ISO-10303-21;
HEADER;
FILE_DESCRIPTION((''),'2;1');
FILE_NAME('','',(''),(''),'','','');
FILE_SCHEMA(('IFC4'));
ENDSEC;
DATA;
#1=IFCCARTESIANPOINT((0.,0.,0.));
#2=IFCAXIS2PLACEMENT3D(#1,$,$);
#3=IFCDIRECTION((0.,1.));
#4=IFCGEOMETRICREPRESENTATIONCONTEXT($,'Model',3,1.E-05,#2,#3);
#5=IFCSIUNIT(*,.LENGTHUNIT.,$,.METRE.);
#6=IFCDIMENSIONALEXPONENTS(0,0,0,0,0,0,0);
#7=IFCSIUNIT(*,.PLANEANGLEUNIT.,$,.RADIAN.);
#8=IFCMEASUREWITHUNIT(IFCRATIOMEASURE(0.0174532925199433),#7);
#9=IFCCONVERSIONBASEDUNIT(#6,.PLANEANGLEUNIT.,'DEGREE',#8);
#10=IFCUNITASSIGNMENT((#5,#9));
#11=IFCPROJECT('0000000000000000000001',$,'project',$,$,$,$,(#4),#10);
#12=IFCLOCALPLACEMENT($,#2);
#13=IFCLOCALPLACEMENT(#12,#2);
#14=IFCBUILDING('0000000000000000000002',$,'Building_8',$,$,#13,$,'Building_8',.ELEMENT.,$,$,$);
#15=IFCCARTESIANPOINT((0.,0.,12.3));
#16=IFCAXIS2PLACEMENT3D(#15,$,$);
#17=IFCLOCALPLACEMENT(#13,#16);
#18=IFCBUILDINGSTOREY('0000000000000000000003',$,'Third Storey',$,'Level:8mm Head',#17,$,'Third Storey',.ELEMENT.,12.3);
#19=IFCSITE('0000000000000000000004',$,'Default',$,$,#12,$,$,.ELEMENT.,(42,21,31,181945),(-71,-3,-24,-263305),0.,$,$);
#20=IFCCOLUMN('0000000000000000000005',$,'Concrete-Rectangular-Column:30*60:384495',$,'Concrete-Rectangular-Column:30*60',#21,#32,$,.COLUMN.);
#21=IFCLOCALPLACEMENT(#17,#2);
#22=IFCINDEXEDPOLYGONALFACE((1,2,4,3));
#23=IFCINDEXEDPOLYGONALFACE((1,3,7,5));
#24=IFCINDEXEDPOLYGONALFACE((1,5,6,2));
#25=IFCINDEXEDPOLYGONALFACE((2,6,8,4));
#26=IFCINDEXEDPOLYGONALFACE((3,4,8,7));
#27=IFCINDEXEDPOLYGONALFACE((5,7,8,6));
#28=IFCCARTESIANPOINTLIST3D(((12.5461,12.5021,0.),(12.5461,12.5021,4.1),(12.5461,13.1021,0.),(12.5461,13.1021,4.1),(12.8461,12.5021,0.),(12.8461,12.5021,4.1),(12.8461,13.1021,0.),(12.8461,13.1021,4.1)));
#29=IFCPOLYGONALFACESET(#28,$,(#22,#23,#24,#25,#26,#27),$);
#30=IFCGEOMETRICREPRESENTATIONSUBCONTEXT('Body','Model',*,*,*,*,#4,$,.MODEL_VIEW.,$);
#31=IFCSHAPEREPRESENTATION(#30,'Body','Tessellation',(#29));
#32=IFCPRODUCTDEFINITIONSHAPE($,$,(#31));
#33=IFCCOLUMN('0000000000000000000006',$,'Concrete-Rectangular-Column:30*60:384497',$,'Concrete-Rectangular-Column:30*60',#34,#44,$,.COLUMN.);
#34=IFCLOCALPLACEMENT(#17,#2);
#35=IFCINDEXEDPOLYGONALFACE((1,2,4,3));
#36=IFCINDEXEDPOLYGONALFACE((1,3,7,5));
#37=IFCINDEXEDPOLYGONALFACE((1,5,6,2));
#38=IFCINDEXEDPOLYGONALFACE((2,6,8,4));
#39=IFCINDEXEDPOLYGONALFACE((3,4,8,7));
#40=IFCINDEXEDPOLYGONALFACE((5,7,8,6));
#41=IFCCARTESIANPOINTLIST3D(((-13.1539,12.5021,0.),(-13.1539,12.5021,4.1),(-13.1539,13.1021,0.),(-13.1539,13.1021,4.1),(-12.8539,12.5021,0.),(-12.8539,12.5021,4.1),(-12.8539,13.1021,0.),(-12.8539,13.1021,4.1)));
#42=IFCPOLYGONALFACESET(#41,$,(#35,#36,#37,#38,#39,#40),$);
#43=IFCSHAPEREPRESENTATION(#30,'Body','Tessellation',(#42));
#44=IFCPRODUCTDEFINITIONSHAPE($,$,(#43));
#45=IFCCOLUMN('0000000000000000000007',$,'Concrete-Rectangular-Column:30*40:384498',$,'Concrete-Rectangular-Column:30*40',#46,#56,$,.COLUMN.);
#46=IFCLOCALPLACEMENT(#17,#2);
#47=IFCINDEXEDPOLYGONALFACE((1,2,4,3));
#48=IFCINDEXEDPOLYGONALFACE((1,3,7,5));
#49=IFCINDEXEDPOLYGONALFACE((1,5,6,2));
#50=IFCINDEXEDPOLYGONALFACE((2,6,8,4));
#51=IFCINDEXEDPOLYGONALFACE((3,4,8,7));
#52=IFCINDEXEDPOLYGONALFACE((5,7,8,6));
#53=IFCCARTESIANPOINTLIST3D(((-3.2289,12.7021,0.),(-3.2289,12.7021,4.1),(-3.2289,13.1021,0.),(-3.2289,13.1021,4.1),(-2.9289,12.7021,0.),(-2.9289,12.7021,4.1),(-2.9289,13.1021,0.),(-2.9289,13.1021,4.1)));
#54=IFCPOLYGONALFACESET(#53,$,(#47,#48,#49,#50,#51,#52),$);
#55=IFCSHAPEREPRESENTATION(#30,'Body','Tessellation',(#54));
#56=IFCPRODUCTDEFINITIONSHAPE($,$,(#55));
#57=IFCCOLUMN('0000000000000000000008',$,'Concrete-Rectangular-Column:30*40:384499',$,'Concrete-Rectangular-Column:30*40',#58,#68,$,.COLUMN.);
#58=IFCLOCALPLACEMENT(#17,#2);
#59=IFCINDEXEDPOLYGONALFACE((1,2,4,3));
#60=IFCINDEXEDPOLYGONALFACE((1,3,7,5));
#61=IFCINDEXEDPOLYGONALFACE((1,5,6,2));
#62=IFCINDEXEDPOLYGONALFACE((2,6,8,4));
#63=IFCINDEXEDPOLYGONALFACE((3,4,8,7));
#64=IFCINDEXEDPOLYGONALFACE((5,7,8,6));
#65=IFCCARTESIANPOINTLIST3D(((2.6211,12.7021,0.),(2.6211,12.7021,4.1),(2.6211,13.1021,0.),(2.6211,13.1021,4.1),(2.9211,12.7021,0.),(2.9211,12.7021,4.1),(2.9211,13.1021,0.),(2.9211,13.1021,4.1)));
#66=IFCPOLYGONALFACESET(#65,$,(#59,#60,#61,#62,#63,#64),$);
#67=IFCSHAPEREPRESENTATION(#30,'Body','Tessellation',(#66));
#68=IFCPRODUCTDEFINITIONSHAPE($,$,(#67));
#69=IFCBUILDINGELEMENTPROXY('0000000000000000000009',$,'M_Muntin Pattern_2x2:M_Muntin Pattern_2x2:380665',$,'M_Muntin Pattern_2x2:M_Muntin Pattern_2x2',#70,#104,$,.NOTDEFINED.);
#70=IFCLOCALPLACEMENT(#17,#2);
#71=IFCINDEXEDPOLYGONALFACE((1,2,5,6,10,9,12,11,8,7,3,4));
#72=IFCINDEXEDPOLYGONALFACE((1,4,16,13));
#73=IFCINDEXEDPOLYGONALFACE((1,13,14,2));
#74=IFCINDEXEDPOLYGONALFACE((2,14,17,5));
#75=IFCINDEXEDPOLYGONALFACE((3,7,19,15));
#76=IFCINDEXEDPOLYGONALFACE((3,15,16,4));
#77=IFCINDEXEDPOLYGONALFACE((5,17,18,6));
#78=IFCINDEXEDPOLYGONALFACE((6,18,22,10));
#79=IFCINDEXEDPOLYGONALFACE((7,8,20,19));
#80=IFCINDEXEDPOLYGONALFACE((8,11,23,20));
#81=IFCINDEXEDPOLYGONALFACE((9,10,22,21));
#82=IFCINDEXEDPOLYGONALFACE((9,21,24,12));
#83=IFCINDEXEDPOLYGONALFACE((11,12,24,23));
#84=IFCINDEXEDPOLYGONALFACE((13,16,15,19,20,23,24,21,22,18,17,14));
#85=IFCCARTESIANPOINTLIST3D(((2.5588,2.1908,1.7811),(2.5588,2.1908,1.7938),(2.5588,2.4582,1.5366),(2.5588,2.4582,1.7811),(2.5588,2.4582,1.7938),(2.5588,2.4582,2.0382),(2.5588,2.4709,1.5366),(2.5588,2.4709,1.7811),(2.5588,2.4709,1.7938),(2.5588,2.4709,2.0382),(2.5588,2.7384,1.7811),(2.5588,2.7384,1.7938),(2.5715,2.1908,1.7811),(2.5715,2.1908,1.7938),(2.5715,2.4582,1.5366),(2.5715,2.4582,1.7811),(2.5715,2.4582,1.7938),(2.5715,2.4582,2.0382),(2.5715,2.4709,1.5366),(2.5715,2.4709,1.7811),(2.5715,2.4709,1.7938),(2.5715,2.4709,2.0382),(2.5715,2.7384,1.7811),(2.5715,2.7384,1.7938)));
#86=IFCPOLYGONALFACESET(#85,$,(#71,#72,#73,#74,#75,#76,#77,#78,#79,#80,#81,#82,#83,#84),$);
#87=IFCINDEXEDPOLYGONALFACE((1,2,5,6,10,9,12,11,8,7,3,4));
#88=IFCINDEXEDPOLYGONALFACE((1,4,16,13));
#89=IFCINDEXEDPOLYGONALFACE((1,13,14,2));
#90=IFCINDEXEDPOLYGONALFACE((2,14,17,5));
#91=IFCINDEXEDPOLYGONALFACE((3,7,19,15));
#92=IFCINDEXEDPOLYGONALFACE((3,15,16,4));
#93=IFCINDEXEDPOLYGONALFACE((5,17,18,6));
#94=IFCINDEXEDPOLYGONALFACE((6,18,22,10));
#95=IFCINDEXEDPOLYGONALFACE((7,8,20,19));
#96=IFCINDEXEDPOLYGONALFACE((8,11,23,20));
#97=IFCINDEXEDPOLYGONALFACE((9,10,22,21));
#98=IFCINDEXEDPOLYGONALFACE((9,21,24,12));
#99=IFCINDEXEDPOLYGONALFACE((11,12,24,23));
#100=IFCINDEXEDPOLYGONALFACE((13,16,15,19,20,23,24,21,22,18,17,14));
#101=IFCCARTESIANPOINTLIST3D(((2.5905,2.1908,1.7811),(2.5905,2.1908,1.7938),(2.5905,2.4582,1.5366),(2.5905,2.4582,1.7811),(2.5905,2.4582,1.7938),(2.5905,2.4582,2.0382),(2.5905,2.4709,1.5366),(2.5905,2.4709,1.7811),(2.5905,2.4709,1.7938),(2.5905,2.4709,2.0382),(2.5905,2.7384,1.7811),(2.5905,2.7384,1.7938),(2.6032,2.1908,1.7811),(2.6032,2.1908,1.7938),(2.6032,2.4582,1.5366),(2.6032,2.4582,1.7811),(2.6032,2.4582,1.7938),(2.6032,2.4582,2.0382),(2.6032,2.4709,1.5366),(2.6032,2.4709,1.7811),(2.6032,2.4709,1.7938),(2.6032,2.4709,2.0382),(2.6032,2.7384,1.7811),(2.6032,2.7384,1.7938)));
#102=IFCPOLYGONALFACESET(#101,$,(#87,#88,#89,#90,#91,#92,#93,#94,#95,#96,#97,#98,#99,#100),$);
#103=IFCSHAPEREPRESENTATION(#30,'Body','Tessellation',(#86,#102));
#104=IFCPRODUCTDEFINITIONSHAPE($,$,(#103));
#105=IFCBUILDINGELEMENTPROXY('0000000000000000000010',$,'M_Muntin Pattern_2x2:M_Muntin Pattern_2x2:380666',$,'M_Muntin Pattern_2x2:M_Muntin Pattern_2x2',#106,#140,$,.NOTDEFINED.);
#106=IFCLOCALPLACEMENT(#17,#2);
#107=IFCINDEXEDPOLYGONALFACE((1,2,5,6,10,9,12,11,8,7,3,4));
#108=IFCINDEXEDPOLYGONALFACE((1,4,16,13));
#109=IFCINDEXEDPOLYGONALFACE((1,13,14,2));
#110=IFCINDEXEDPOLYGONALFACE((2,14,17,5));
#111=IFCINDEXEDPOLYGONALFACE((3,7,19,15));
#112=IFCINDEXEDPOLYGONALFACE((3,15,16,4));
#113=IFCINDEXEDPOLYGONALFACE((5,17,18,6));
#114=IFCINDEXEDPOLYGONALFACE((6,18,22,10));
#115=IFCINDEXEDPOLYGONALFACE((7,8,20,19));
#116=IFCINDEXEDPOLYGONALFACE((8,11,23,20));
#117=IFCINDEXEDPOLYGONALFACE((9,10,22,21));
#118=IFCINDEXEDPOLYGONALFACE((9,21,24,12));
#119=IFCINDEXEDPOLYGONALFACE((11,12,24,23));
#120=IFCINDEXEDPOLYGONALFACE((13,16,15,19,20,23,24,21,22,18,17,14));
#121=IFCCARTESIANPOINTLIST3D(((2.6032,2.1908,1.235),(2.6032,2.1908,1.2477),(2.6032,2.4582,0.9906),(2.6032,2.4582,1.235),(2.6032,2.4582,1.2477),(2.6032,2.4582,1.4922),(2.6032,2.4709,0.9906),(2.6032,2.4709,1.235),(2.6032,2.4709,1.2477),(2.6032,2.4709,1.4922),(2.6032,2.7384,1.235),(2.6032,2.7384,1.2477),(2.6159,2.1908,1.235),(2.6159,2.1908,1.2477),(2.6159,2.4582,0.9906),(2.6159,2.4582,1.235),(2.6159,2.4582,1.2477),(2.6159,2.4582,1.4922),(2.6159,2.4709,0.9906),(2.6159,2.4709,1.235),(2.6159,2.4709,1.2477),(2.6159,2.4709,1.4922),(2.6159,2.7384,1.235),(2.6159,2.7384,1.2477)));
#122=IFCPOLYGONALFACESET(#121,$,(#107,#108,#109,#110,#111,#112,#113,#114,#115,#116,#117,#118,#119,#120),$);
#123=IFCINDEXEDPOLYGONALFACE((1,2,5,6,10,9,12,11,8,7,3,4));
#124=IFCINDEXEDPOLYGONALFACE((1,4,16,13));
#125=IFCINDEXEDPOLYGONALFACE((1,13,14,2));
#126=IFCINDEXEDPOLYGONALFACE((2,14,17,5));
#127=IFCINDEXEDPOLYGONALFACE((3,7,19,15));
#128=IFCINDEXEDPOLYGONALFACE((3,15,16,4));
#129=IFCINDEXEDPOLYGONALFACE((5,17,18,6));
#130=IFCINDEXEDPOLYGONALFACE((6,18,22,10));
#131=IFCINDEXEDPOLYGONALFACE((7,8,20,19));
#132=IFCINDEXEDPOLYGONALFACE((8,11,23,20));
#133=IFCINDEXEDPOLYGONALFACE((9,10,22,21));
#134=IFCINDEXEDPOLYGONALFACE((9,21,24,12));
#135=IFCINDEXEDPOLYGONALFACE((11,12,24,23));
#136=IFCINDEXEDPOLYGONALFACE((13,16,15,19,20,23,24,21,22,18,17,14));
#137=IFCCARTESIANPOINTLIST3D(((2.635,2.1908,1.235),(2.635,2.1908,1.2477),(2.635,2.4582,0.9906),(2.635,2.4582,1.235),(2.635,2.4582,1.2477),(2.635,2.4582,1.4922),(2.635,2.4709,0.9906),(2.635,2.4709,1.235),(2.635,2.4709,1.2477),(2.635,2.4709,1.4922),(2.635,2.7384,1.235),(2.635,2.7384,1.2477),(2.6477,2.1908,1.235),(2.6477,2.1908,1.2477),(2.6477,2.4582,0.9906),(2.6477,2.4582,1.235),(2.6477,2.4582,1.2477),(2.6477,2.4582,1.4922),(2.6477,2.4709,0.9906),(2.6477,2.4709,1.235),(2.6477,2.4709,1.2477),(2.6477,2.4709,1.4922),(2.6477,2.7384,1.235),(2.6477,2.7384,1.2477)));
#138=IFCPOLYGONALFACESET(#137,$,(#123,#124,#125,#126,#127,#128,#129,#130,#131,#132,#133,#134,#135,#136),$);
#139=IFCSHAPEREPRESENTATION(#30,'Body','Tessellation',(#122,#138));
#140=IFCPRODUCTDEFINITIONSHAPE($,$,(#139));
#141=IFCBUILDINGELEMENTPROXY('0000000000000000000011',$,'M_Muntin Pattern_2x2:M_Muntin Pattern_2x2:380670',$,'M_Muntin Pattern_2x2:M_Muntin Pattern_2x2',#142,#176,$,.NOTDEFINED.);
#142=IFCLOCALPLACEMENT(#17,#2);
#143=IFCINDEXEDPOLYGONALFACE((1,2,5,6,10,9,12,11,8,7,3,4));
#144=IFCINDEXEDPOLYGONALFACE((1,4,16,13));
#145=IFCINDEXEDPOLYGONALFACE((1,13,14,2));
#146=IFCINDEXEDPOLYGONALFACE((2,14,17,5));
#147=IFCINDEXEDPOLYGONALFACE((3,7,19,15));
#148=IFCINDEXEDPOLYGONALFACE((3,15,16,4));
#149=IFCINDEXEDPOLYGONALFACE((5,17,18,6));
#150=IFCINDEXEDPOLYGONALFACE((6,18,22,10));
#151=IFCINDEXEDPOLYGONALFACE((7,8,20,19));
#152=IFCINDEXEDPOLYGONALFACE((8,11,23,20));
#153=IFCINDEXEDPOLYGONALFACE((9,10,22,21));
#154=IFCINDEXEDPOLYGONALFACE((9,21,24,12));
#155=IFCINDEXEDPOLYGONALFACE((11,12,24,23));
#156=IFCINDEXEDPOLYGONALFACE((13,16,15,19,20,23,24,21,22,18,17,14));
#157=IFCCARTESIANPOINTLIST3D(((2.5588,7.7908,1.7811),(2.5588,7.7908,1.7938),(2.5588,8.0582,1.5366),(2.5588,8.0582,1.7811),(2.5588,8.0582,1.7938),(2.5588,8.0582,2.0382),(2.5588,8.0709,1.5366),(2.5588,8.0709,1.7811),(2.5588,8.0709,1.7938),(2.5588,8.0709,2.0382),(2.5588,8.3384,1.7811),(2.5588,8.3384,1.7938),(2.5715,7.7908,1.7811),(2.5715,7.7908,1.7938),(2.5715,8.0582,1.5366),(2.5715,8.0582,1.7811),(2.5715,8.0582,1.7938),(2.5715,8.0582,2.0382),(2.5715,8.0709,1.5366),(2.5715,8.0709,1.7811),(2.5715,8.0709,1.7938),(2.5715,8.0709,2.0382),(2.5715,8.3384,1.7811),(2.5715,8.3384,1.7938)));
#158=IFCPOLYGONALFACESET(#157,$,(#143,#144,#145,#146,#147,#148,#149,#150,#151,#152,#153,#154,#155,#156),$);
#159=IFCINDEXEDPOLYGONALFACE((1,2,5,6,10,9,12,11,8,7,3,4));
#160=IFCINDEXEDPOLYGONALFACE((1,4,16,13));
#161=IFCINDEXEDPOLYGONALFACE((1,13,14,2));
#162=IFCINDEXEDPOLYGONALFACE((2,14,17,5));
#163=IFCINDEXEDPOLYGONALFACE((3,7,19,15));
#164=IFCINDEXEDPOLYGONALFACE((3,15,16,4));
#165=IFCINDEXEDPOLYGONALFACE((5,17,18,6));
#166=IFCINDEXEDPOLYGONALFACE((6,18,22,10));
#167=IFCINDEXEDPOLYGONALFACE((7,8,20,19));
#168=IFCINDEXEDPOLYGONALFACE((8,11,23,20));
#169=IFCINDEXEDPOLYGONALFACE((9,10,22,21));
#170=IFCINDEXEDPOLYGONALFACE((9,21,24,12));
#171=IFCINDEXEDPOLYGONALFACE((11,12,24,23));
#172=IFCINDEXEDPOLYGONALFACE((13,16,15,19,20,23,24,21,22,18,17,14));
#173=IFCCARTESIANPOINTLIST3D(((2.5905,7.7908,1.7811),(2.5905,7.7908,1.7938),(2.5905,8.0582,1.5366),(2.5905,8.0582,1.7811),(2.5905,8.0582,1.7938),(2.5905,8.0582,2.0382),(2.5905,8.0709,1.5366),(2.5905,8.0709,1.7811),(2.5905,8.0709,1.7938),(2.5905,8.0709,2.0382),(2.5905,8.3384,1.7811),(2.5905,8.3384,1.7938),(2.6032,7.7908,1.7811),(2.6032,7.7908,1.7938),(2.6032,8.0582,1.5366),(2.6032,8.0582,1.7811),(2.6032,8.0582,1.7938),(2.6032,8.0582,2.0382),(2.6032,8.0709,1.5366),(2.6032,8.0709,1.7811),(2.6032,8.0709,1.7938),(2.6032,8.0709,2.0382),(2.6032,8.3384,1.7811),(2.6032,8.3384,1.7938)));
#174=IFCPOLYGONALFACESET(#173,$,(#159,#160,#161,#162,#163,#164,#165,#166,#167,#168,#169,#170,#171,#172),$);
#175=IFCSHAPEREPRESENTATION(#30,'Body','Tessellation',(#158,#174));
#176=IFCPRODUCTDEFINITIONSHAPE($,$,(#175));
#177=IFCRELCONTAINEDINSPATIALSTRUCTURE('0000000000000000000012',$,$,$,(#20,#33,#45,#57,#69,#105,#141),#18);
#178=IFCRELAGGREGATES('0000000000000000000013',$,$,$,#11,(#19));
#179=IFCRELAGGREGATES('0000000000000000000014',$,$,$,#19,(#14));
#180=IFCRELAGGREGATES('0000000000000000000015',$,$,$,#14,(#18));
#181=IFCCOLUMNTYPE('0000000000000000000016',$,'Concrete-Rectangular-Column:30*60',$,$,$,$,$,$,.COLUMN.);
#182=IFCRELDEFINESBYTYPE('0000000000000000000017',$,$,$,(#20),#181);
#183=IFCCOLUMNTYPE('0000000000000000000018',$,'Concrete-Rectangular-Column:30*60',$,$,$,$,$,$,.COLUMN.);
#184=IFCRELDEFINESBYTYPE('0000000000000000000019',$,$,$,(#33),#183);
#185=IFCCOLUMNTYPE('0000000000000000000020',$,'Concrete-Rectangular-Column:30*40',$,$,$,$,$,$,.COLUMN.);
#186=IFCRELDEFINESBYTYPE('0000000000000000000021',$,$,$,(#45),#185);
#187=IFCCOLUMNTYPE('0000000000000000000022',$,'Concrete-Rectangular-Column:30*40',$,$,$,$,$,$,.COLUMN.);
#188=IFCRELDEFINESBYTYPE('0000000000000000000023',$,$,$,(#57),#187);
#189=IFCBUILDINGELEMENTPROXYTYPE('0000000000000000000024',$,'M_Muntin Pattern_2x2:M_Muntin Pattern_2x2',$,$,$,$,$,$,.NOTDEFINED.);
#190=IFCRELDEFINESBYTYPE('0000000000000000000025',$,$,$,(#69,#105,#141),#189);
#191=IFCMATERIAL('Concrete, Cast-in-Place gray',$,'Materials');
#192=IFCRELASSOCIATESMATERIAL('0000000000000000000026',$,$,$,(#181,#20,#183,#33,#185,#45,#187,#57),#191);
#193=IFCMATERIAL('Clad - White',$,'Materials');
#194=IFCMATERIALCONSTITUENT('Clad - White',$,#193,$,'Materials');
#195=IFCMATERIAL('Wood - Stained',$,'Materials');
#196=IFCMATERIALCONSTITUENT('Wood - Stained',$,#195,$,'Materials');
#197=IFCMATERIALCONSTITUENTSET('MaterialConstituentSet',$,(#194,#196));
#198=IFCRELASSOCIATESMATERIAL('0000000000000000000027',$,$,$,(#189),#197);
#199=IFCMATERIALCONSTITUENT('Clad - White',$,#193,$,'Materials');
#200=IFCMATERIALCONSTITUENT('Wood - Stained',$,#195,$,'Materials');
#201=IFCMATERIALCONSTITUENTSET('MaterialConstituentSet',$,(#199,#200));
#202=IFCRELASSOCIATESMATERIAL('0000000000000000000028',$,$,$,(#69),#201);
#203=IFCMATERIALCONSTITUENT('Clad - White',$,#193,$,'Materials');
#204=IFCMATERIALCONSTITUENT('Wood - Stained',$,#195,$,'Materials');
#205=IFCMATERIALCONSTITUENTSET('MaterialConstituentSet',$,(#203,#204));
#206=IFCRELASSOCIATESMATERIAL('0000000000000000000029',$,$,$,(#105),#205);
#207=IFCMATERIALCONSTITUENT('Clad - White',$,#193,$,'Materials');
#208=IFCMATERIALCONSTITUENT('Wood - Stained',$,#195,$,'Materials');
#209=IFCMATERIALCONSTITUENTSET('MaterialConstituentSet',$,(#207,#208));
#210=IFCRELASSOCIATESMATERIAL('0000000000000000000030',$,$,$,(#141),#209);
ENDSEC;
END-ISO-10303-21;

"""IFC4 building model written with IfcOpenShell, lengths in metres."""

from ifc_helpers import new_model, entity, si_unit, converted_unit, direction, frame, origin, place, context, subcontext, project, spatial, indexed_curve, outline, extrude, source, transform, mapped, material, constituent, constituent_set, type_object, type_shapes, element, save


model = new_model("IFC4")

# Units and contexts
model_context = context("Model", 3, precision=1e-05, world=origin(), true_north=direction((0.0, 1.0)))
body_context = subcontext(model_context, "Body", "Model", "MODEL_VIEW")
ifc_project = project(units=[si_unit("LENGTHUNIT", "METRE"), converted_unit("PLANEANGLEUNIT", "DEGREE", entity("IfcRatioMeasure", 0.0174532925199433), si_unit("PLANEANGLEUNIT", "RADIAN"), dimensions=[0, 0, 0, 0, 0, 0, 0])], contexts=[model_context])

# Site, building, storey
site_placement = place(None, origin())
site = spatial("IfcSite", under=ifc_project, at=site_placement, Name="Default", CompositionType="ELEMENT", RefLatitude=(42, 21, 31, 181945), RefLongitude=(-71, -3, -24, -263305), RefElevation=0.0)
building_placement = place(site_placement, origin())
building = spatial("IfcBuilding", under=site, at=building_placement, Name="Building_8", LongName="Building_8", CompositionType="ELEMENT")
storey_placement = place(building_placement, frame((0.0, 0.0, 12.3)))
storey = spatial("IfcBuildingStorey", under=building, at=storey_placement, Name="Third Storey", ObjectType="Level:8mm Head", LongName="Third Storey", CompositionType="ELEMENT", Elevation=12.3)

# Columns
ifc_material_1 = material(Name="Concrete, Cast-in-Place gray", Category="Materials")
column_type_1 = type_object("IfcColumnType", Name="Concrete-Rectangular-Column:30*60", PredefinedType="COLUMN", material=ifc_material_1)
shared_shape_1 = source(origin(), body_context, "Body", "SweptSolid", [
    extrude(outline(indexed_curve([(-0.3, -0.15), (0.3, -0.15), (0.3, 0.15), (-0.3, 0.15), (-0.3, -0.15)], self_intersect=False)), frame((12.6961, 12.8021, 12.3), z_axis=(0.0, 0.0, 1.0), x_axis=(0.0, -1.0, 0.0)), (0.0, 0.0, 1.0), 4.1),
])
type_shapes(column_type_1, [shared_shape_1])
column_1_placement = place(storey_placement, frame((0.0, 0.0, -12.3)))
element("IfcColumn", 1, at=column_1_placement, inside=storey, type_object=column_type_1, material=ifc_material_1, Name="Concrete-Rectangular-Column:30*60:384495", ObjectType="Concrete-Rectangular-Column:30*60", PredefinedType="COLUMN", context=body_context, shape_type="MappedRepresentation", body=[
    mapped(shared_shape_1, transform((0.0, 0.0, 0.0), scale=1.0)),
])
column_type_2 = type_object("IfcColumnType", Name="Concrete-Rectangular-Column:30*60", PredefinedType="COLUMN", material=ifc_material_1)
shared_shape_2 = source(origin(), body_context, "Body", "SweptSolid", [
    extrude(outline(indexed_curve([(-0.3, -0.15), (0.3, -0.15), (0.3, 0.15), (-0.3, 0.15), (-0.3, -0.15)], self_intersect=False)), frame((-13.0039, 12.8021, 12.3), z_axis=(0.0, 0.0, 1.0), x_axis=(0.0, -1.0, 0.0)), (0.0, 0.0, 1.0), 4.1),
])
type_shapes(column_type_2, [shared_shape_2])
column_2_placement = place(storey_placement, frame((0.0, 0.0, -12.3)))
element("IfcColumn", 2, at=column_2_placement, inside=storey, type_object=column_type_2, material=ifc_material_1, Name="Concrete-Rectangular-Column:30*60:384497", ObjectType="Concrete-Rectangular-Column:30*60", PredefinedType="COLUMN", context=body_context, shape_type="MappedRepresentation", body=[
    mapped(shared_shape_2, transform((0.0, 0.0, 0.0), scale=1.0)),
])
column_type_3 = type_object("IfcColumnType", Name="Concrete-Rectangular-Column:30*40", PredefinedType="COLUMN", material=ifc_material_1)
shared_shape_3 = source(origin(), body_context, "Body", "SweptSolid", [
    extrude(outline(indexed_curve([(-0.2, -0.15), (0.2, -0.15), (0.2, 0.15), (-0.2, 0.15), (-0.2, -0.15)], self_intersect=False)), frame((-3.0789, 12.9021, 12.3), z_axis=(0.0, 0.0, 1.0), x_axis=(0.0, -1.0, 0.0)), (0.0, 0.0, 1.0), 4.1),
])
type_shapes(column_type_3, [shared_shape_3])
column_3_placement = place(storey_placement, frame((0.0, 0.0, -12.3)))
element("IfcColumn", 3, at=column_3_placement, inside=storey, type_object=column_type_3, material=ifc_material_1, Name="Concrete-Rectangular-Column:30*40:384498", ObjectType="Concrete-Rectangular-Column:30*40", PredefinedType="COLUMN", context=body_context, shape_type="MappedRepresentation", body=[
    mapped(shared_shape_3, transform((0.0, 0.0, 0.0), scale=1.0)),
])
column_type_4 = type_object("IfcColumnType", Name="Concrete-Rectangular-Column:30*40", PredefinedType="COLUMN", material=ifc_material_1)
shared_shape_4 = source(origin(), body_context, "Body", "SweptSolid", [
    extrude(outline(indexed_curve([(-0.2, -0.15), (0.2, -0.15), (0.2, 0.15), (-0.2, 0.15), (-0.2, -0.15)], self_intersect=False)), frame((2.7711, 12.9021, 12.3), z_axis=(0.0, 0.0, 1.0), x_axis=(0.0, -1.0, 0.0)), (0.0, 0.0, 1.0), 4.1),
])
type_shapes(column_type_4, [shared_shape_4])
column_4_placement = place(storey_placement, frame((0.0, 0.0, -12.3)))
element("IfcColumn", 4, at=column_4_placement, inside=storey, type_object=column_type_4, material=ifc_material_1, Name="Concrete-Rectangular-Column:30*40:384499", ObjectType="Concrete-Rectangular-Column:30*40", PredefinedType="COLUMN", context=body_context, shape_type="MappedRepresentation", body=[
    mapped(shared_shape_4, transform((0.0, 0.0, 0.0), scale=1.0)),
])

# Building element proxies
ifc_material_2 = material(Name="Clad - White", Category="Materials")
ifc_constituent_1 = constituent(ifc_material_2, Name="Clad - White", Category="Materials")
ifc_material_3 = material(Name="Wood - Stained", Category="Materials")
ifc_constituent_2 = constituent(ifc_material_3, Name="Wood - Stained", Category="Materials")
ifc_constituent_set_1 = constituent_set(constituents=[ifc_constituent_1, ifc_constituent_2], Name="MaterialConstituentSet")
ifc_constituent_3 = constituent(ifc_material_2, Name="Clad - White", Category="Materials")
ifc_constituent_4 = constituent(ifc_material_3, Name="Wood - Stained", Category="Materials")
ifc_constituent_set_2 = constituent_set(constituents=[ifc_constituent_3, ifc_constituent_4], Name="MaterialConstituentSet")
building_element_proxy_type_1 = type_object("IfcBuildingElementProxyType", Name="M_Muntin Pattern_2x2:M_Muntin Pattern_2x2", PredefinedType="NOTDEFINED", material=ifc_constituent_set_2)
shared_shape_5 = source(origin(), body_context, "Body", "SweptSolid", [
    extrude(outline(indexed_curve([(0.0064, -0.0064), (0.2508, -0.0064), (0.2508, 0.0063), (0.0064, 0.0063), (0.0064, 0.2738), (-0.0063, 0.2738), (-0.0063, 0.0063), (-0.2508, 0.0063), (-0.2508, -0.0064), (-0.0063, -0.0064), (-0.0063, -0.2738), (0.0064, -0.2738), (0.0064, -0.0064)], self_intersect=False)), frame((0.0, 0.0095, 0.2508), z_axis=(0.0, 1.0, 0.0), x_axis=(0.0, 0.0, 1.0)), (0.0, 0.0, 1.0), 0.0127),
    extrude(outline(indexed_curve([(0.0064, -0.0064), (0.2508, -0.0064), (0.2508, 0.0063), (0.0064, 0.0063), (0.0064, 0.2738), (-0.0063, 0.2738), (-0.0063, 0.0063), (-0.2508, 0.0063), (-0.2508, -0.0064), (-0.0063, -0.0064), (-0.0063, -0.2738), (0.0064, -0.2738), (0.0064, -0.0064)], self_intersect=False)), frame((0.0, -0.0222, 0.2508), z_axis=(0.0, 1.0, 0.0), x_axis=(0.0, 0.0, 1.0)), (0.0, 0.0, 1.0), 0.0127),
])
type_shapes(building_element_proxy_type_1, [shared_shape_5])
proxy_1_placement = place(storey_placement, frame((2.581, 2.4646, 1.5366), z_axis=(0.0, 0.0, 1.0), x_axis=(0.0, 1.0, 0.0)))
element("IfcBuildingElementProxy", 5, at=proxy_1_placement, inside=storey, type_object=building_element_proxy_type_1, material=ifc_constituent_set_1, Name="M_Muntin Pattern_2x2:M_Muntin Pattern_2x2:380665", ObjectType="M_Muntin Pattern_2x2:M_Muntin Pattern_2x2", PredefinedType="NOTDEFINED", context=body_context, shape_type="MappedRepresentation", body=[
    mapped(shared_shape_5, transform((0.0, 0.0, 0.0), scale=1.0)),
])
ifc_constituent_5 = constituent(ifc_material_2, Name="Clad - White", Category="Materials")
ifc_constituent_6 = constituent(ifc_material_3, Name="Wood - Stained", Category="Materials")
ifc_constituent_set_3 = constituent_set(constituents=[ifc_constituent_5, ifc_constituent_6], Name="MaterialConstituentSet")
proxy_2_placement = place(storey_placement, frame((2.6255, 2.4646, 0.9906), z_axis=(0.0, 0.0, 1.0), x_axis=(0.0, 1.0, 0.0)))
element("IfcBuildingElementProxy", 6, at=proxy_2_placement, inside=storey, type_object=building_element_proxy_type_1, material=ifc_constituent_set_3, Name="M_Muntin Pattern_2x2:M_Muntin Pattern_2x2:380666", ObjectType="M_Muntin Pattern_2x2:M_Muntin Pattern_2x2", PredefinedType="NOTDEFINED", context=body_context, shape_type="MappedRepresentation", body=[
    mapped(shared_shape_5, transform((0.0, 0.0, 0.0), scale=1.0)),
])
ifc_constituent_7 = constituent(ifc_material_2, Name="Clad - White", Category="Materials")
ifc_constituent_8 = constituent(ifc_material_3, Name="Wood - Stained", Category="Materials")
ifc_constituent_set_4 = constituent_set(constituents=[ifc_constituent_7, ifc_constituent_8], Name="MaterialConstituentSet")
proxy_3_placement = place(storey_placement, frame((2.581, 8.0646, 1.5366), z_axis=(0.0, 0.0, 1.0), x_axis=(0.0, 1.0, 0.0)))
element("IfcBuildingElementProxy", 7, at=proxy_3_placement, inside=storey, type_object=building_element_proxy_type_1, material=ifc_constituent_set_4, Name="M_Muntin Pattern_2x2:M_Muntin Pattern_2x2:380670", ObjectType="M_Muntin Pattern_2x2:M_Muntin Pattern_2x2", PredefinedType="NOTDEFINED", context=body_context, shape_type="MappedRepresentation", body=[
    mapped(shared_shape_5, transform((0.0, 0.0, 0.0), scale=1.0)),
])

save(model, "model.ifc")
